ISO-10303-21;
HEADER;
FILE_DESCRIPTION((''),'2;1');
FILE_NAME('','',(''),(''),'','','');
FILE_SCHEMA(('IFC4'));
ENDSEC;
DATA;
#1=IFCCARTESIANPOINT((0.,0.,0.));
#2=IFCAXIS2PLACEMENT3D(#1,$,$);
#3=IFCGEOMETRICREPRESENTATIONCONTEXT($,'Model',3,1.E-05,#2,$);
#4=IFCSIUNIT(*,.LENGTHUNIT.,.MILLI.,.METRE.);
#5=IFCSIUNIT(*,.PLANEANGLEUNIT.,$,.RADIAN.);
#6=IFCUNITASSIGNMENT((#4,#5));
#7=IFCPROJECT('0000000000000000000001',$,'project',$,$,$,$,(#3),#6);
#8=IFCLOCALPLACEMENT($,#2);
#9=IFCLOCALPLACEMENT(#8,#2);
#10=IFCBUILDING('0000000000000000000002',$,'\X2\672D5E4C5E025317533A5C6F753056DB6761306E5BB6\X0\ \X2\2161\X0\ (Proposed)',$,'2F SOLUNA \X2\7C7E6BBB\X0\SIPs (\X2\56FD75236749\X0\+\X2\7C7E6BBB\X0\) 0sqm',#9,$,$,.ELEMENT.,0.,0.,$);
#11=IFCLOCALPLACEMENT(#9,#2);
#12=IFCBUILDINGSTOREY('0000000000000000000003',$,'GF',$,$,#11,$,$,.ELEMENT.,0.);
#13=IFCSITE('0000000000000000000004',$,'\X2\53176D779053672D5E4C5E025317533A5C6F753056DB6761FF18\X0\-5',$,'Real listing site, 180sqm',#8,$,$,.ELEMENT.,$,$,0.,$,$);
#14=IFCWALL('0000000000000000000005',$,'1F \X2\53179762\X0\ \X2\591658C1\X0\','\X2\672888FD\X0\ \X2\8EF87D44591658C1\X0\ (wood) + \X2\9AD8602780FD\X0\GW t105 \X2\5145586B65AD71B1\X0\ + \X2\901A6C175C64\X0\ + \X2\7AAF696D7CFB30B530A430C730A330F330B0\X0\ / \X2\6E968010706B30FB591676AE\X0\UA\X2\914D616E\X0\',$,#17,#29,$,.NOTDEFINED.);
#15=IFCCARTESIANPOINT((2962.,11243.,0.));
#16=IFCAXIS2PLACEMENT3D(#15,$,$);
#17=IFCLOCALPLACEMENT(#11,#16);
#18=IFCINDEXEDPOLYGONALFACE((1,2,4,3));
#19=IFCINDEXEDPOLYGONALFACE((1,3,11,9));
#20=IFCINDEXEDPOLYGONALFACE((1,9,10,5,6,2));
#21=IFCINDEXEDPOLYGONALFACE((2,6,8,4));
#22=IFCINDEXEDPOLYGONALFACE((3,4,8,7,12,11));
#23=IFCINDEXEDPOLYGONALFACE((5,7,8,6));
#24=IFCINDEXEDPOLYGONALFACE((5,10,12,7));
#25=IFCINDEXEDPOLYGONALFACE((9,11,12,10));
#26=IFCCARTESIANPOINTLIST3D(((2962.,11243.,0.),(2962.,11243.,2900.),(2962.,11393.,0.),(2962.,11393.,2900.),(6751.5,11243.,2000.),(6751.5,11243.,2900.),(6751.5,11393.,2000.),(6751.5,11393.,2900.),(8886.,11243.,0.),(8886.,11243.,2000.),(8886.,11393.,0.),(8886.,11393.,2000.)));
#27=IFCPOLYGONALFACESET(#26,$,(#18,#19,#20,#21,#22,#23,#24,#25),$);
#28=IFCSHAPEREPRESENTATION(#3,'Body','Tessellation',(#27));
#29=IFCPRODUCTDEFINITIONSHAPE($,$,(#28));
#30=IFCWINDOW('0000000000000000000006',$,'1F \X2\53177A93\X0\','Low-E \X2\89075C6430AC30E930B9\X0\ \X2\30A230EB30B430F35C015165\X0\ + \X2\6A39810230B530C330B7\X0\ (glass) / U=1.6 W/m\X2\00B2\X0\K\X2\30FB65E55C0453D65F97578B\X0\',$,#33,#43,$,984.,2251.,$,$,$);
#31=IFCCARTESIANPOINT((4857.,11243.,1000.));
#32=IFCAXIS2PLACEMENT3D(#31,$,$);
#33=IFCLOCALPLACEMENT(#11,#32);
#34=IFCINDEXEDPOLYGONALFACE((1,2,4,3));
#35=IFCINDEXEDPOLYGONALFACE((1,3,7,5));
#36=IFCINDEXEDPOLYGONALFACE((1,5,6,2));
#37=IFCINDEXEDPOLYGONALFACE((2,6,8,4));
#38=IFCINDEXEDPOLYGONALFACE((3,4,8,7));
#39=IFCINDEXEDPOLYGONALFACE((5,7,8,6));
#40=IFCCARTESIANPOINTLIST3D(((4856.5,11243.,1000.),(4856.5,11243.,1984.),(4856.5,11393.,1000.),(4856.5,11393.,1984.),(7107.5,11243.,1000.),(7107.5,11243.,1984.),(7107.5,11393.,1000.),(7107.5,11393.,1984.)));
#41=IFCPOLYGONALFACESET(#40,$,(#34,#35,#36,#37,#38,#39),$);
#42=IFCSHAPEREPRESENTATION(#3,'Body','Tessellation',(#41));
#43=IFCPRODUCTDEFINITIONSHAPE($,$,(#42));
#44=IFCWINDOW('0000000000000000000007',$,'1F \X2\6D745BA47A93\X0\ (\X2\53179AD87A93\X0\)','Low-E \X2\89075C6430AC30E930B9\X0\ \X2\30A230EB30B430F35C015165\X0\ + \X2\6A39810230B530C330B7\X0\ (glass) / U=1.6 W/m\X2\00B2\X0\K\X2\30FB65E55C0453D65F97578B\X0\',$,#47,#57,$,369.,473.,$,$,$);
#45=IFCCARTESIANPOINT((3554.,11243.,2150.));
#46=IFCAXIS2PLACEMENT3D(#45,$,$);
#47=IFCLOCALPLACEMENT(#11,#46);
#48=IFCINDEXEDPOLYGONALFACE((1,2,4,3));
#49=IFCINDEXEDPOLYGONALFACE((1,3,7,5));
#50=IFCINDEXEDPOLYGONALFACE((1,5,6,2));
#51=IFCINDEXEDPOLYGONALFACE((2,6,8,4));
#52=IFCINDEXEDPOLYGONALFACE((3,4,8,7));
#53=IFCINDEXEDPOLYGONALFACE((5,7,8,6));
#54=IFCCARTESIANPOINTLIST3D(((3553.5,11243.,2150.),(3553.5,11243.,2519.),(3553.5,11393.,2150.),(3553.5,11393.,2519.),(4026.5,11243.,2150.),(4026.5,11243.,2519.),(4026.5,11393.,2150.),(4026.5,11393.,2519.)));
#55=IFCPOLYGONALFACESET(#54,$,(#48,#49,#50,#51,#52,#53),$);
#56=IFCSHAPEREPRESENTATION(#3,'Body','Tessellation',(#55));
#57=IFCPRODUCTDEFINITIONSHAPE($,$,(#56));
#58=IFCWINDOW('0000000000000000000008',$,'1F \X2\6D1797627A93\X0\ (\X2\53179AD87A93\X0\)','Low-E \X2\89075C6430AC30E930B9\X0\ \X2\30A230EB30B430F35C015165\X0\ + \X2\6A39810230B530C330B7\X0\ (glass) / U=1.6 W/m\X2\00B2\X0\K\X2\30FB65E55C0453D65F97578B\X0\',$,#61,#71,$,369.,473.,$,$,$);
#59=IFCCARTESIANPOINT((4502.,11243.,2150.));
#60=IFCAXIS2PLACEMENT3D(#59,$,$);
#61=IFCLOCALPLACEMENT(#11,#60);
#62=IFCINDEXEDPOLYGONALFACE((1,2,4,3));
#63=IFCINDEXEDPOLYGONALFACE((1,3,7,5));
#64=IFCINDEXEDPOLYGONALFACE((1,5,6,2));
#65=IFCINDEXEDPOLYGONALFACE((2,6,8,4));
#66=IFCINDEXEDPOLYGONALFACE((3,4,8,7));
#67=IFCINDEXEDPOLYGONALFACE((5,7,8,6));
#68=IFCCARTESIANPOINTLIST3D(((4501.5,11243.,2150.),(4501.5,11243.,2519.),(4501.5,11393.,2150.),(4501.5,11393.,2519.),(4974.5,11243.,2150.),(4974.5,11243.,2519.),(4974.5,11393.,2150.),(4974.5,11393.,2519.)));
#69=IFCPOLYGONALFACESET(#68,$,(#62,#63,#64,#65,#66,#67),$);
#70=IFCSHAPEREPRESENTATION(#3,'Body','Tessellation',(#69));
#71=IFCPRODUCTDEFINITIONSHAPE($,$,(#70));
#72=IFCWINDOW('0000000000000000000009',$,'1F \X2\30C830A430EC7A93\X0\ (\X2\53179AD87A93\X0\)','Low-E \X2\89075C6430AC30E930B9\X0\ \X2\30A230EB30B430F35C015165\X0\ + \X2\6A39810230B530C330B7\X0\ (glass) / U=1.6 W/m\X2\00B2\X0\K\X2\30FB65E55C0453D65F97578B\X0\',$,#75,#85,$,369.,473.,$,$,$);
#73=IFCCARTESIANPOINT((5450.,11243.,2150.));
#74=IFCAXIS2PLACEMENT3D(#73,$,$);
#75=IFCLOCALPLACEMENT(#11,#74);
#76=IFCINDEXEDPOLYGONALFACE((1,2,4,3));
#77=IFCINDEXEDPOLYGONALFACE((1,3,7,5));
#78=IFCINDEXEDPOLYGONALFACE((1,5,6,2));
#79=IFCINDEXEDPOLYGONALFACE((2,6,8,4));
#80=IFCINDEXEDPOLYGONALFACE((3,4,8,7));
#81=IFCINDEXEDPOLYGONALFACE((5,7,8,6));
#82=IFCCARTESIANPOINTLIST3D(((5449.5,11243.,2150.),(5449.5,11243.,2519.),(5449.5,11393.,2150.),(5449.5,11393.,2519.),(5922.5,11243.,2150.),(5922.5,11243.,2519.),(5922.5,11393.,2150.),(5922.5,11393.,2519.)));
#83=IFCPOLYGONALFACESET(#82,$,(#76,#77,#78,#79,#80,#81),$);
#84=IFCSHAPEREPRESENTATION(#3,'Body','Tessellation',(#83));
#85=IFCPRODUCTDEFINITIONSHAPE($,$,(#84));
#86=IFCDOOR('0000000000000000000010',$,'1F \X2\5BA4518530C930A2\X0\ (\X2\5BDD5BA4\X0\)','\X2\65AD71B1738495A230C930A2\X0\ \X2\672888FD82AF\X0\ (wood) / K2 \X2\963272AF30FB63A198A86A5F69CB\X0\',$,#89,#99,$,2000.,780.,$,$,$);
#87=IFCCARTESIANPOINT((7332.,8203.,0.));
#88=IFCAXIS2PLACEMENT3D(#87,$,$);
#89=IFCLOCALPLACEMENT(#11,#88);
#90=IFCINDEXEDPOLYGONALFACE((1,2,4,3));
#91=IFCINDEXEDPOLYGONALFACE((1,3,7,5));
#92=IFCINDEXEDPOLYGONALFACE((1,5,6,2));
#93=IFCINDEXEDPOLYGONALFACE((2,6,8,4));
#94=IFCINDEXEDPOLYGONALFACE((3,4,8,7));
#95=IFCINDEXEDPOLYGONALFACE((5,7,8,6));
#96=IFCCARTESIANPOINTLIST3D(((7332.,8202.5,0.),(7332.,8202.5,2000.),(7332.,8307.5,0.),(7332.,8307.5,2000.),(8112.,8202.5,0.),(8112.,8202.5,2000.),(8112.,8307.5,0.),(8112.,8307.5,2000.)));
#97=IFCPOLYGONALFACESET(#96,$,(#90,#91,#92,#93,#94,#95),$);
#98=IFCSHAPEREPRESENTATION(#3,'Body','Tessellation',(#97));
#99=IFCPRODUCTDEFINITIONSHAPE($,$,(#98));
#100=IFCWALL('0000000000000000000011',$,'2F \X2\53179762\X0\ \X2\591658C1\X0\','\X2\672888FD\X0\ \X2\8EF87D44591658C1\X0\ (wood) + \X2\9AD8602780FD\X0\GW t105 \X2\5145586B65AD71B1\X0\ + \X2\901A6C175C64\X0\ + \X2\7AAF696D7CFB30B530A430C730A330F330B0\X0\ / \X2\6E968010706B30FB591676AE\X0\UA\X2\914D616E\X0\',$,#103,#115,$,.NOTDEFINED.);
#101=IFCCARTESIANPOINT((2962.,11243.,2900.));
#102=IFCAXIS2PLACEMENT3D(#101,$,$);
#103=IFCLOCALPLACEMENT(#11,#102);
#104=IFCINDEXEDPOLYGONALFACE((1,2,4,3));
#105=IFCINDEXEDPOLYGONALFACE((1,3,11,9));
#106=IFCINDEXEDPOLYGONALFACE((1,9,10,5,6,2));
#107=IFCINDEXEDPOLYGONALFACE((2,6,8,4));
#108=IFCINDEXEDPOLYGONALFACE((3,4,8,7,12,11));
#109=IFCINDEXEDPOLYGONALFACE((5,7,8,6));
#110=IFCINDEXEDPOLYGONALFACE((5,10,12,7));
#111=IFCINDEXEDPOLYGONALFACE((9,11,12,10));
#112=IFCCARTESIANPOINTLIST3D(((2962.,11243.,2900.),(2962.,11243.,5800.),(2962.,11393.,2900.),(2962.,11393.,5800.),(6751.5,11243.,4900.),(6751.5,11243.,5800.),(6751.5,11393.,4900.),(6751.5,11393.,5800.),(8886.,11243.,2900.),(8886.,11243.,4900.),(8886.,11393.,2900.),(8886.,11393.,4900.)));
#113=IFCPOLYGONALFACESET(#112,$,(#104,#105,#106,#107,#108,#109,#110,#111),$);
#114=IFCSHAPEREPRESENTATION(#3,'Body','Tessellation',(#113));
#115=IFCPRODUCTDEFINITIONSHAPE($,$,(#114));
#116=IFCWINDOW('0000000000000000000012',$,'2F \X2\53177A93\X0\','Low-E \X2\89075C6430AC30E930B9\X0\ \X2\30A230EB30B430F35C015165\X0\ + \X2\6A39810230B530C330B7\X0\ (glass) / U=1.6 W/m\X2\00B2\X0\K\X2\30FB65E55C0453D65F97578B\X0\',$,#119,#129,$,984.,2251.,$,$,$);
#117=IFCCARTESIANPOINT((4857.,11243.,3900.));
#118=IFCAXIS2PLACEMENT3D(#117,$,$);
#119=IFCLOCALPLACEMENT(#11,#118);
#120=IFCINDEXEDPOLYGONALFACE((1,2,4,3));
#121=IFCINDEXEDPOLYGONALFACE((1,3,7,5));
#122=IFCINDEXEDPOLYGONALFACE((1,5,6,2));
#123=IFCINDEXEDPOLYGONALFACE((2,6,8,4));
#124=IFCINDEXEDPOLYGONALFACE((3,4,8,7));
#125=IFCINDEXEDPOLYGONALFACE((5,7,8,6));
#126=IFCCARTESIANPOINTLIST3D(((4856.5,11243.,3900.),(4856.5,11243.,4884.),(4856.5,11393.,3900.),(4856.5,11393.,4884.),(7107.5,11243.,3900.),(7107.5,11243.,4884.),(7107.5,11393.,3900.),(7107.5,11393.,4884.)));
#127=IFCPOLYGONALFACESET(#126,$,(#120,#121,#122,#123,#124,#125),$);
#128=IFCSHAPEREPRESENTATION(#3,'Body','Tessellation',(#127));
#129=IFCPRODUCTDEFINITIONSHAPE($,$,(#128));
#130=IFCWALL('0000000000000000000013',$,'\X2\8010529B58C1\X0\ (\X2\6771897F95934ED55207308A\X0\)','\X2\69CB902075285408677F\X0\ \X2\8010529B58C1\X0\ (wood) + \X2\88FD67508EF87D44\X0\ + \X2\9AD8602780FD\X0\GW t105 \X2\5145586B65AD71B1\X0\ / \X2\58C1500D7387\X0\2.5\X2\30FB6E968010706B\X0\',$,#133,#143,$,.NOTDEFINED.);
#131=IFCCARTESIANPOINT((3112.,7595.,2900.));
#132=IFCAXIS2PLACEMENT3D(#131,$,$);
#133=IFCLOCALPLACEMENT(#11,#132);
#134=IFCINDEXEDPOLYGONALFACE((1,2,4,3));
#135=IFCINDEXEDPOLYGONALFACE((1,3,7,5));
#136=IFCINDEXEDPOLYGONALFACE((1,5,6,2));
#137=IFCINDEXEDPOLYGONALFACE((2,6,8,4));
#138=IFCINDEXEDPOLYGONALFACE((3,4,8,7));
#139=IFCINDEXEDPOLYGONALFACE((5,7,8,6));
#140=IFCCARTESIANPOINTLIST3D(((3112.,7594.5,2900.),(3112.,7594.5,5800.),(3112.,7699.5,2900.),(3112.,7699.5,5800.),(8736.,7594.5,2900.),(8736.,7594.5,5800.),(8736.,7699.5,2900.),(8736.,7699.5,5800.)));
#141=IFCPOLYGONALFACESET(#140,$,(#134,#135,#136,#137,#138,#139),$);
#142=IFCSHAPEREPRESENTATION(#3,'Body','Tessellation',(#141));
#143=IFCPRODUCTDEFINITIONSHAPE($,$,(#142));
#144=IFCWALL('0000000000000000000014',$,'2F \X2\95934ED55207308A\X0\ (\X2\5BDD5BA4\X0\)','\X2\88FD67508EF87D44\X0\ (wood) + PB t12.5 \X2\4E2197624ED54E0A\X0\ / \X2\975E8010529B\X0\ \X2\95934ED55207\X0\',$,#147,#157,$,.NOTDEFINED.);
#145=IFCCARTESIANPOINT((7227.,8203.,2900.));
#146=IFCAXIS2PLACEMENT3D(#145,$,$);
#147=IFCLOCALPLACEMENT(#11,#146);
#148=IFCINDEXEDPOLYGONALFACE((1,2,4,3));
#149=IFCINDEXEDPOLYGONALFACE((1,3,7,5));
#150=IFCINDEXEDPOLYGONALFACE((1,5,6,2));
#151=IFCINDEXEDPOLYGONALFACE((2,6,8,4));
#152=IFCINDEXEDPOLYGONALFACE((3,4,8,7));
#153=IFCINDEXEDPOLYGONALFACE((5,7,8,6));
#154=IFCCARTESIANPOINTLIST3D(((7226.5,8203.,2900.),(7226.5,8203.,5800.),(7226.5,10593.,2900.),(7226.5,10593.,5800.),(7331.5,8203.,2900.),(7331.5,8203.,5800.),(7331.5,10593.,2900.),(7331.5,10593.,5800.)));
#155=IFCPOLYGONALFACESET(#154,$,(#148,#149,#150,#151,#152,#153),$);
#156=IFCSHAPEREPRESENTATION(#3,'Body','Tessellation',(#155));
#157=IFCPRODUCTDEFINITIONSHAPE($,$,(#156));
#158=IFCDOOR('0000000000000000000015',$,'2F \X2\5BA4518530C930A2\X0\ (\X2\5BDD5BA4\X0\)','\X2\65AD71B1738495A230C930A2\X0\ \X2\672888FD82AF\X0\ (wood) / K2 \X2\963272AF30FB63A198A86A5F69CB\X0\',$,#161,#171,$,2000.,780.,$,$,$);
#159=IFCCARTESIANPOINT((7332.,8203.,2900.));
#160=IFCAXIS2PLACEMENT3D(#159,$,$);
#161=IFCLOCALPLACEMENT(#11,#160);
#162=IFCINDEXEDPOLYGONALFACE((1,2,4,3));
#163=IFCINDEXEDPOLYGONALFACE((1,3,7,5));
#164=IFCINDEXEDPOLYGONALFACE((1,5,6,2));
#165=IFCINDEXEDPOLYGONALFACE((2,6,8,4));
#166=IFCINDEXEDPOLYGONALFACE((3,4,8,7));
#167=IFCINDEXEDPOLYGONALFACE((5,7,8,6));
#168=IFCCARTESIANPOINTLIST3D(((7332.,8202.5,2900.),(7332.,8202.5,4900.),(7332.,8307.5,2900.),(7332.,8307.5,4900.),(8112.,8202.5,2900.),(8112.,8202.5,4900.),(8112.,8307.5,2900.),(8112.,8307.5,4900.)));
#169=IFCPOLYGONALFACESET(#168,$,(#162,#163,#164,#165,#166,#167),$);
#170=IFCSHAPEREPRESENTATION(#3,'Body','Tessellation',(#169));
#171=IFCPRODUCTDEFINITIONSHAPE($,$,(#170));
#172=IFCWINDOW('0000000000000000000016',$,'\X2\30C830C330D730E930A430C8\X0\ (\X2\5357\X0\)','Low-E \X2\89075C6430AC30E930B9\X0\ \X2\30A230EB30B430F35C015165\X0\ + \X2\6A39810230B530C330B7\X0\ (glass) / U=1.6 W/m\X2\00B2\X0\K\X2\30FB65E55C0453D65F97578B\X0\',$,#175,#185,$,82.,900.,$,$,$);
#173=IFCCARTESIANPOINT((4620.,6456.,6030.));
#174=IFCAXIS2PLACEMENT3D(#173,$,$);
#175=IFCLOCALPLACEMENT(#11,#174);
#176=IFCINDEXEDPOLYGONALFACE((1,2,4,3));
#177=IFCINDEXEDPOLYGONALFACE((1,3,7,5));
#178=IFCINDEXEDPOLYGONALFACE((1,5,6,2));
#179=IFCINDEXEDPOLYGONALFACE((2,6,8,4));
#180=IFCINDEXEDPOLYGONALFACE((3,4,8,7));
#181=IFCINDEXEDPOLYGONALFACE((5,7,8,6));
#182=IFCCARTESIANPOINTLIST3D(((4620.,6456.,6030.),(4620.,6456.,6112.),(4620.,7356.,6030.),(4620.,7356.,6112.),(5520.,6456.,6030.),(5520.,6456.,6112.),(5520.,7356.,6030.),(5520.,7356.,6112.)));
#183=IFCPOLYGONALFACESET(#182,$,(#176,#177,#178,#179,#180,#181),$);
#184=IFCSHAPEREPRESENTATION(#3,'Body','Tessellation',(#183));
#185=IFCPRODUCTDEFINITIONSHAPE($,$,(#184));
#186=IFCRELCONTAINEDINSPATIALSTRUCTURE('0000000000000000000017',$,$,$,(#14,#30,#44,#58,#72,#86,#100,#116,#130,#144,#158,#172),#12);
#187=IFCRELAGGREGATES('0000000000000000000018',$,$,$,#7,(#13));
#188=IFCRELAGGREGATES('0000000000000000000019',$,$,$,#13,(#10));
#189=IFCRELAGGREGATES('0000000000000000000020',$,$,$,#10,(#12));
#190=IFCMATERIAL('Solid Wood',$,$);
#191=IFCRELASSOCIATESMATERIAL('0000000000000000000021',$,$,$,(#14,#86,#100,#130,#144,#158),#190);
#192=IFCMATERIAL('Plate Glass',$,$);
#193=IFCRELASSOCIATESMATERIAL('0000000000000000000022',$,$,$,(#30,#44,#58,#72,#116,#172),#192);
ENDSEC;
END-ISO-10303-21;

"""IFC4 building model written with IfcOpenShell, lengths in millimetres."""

from ifc_helpers import new_model, si_unit, frame, frame_2d, origin, place, context, project, spatial, rectangle, extrude, material, element, fill, save


model = new_model("IFC4")

# Units and contexts
model_context = context("Model", 3, precision=1e-05, world=origin())
ifc_project = project(units=[si_unit("LENGTHUNIT", "METRE", prefix="MILLI"), si_unit("PLANEANGLEUNIT", "RADIAN")], contexts=[model_context])

# Site, building, storey
site_placement = place(None, origin())
site = spatial("IfcSite", under=ifc_project, at=site_placement, Name="北海道札幌市北区屯田四条８-5", ObjectType="Real listing site, 180sqm", CompositionType="ELEMENT", RefElevation=0.0)
building_placement = place(site_placement, origin())
building = spatial("IfcBuilding", under=site, at=building_placement, Name="札幌市北区屯田四条の家 Ⅱ (Proposed)", ObjectType="2F SOLUNA 籾殻SIPs (国産杉+籾殻) 0sqm", CompositionType="ELEMENT", ElevationOfRefHeight=0.0, ElevationOfTerrain=0.0)
storey_placement = place(building_placement, origin())
storey = spatial("IfcBuildingStorey", under=building, at=storey_placement, Name="GF", CompositionType="ELEMENT", Elevation=0.0)

# Wall, openings, windows
ifc_material_1 = material(Name="Solid Wood")
wall_1_placement = place(storey_placement, frame((2962.0, 11243.0, 0.0)))
wall_1 = element("IfcWall", 1, at=wall_1_placement, inside=storey, material=ifc_material_1, Name="1F 北面 外壁", Description="木製 軸組外壁 (wood) + 高性能GW t105 充填断熱 + 通気層 + 窯業系サイディング / 準耐火・外皮UA配慮", PredefinedType="NOTDEFINED", context=model_context, shape_type="SweptSolid", body=[
    extrude(rectangle(XDim=5924.0, YDim=150.0, at=frame_2d((2962.0, 75.0))), frame((2962.0, 11243.0, 0.0)), (0.0, 0.0, 1.0), 2900.0),
])
opening_1_placement = place(storey_placement, frame((4857.0, 11243.0, 1000.0)))
opening_1 = element("IfcOpeningElement", 2, at=opening_1_placement, cuts=wall_1, PredefinedType="NOTDEFINED", context=model_context, shape_type="SweptSolid", body=[
    extrude(rectangle(XDim=2251.0, YDim=150.0, at=frame_2d((1125.0, 75.0))), frame((4857.0, 11243.0, 1000.0)), (0.0, 0.0, 1.0), 984.0),
])
opening_2_placement = place(storey_placement, frame((3554.0, 11243.0, 2150.0)))
opening_2 = element("IfcOpeningElement", 3, at=opening_2_placement, cuts=wall_1, PredefinedType="NOTDEFINED", context=model_context, shape_type="SweptSolid", body=[
    extrude(rectangle(XDim=473.0, YDim=150.0, at=frame_2d((236.0, 75.0))), frame((3554.0, 11243.0, 2150.0)), (0.0, 0.0, 1.0), 369.0),
])
opening_3_placement = place(storey_placement, frame((4502.0, 11243.0, 2150.0)))
opening_3 = element("IfcOpeningElement", 4, at=opening_3_placement, cuts=wall_1, PredefinedType="NOTDEFINED", context=model_context, shape_type="SweptSolid", body=[
    extrude(rectangle(XDim=473.0, YDim=150.0, at=frame_2d((236.0, 75.0))), frame((4502.0, 11243.0, 2150.0)), (0.0, 0.0, 1.0), 369.0),
])
opening_4_placement = place(storey_placement, frame((5450.0, 11243.0, 2150.0)))
opening_4 = element("IfcOpeningElement", 5, at=opening_4_placement, cuts=wall_1, PredefinedType="NOTDEFINED", context=model_context, shape_type="SweptSolid", body=[
    extrude(rectangle(XDim=473.0, YDim=150.0, at=frame_2d((236.0, 75.0))), frame((5450.0, 11243.0, 2150.0)), (0.0, 0.0, 1.0), 369.0),
])
ifc_material_2 = material(Name="Plate Glass")
window_1_placement = place(storey_placement, frame((4857.0, 11243.0, 1000.0)))
window_1 = element("IfcWindow", 6, at=window_1_placement, inside=storey, material=ifc_material_2, Name="1F 北窓", Description="Low-E 複層ガラス アルゴン封入 + 樹脂サッシ (glass) / U=1.6 W/m²K・日射取得型", OverallHeight=984.0, OverallWidth=2251.0, context=model_context, shape_type="SweptSolid", body=[
    extrude(rectangle(XDim=2251.0, YDim=150.0, at=frame_2d((1125.0, 75.0))), frame((4857.0, 11243.0, 1000.0)), (0.0, 0.0, 1.0), 984.0),
])
fill(opening_1, window_1)
window_2_placement = place(storey_placement, frame((3554.0, 11243.0, 2150.0)))
window_2 = element("IfcWindow", 7, at=window_2_placement, inside=storey, material=ifc_material_2, Name="1F 浴室窓 (北高窓)", Description="Low-E 複層ガラス アルゴン封入 + 樹脂サッシ (glass) / U=1.6 W/m²K・日射取得型", OverallHeight=369.0, OverallWidth=473.0, context=model_context, shape_type="SweptSolid", body=[
    extrude(rectangle(XDim=473.0, YDim=150.0, at=frame_2d((236.0, 75.0))), frame((3554.0, 11243.0, 2150.0)), (0.0, 0.0, 1.0), 369.0),
])
fill(opening_2, window_2)
window_3_placement = place(storey_placement, frame((4502.0, 11243.0, 2150.0)))
window_3 = element("IfcWindow", 8, at=window_3_placement, inside=storey, material=ifc_material_2, Name="1F 洗面窓 (北高窓)", Description="Low-E 複層ガラス アルゴン封入 + 樹脂サッシ (glass) / U=1.6 W/m²K・日射取得型", OverallHeight=369.0, OverallWidth=473.0, context=model_context, shape_type="SweptSolid", body=[
    extrude(rectangle(XDim=473.0, YDim=150.0, at=frame_2d((236.0, 75.0))), frame((4502.0, 11243.0, 2150.0)), (0.0, 0.0, 1.0), 369.0),
])
fill(opening_3, window_3)
window_4_placement = place(storey_placement, frame((5450.0, 11243.0, 2150.0)))
window_4 = element("IfcWindow", 9, at=window_4_placement, inside=storey, material=ifc_material_2, Name="1F トイレ窓 (北高窓)", Description="Low-E 複層ガラス アルゴン封入 + 樹脂サッシ (glass) / U=1.6 W/m²K・日射取得型", OverallHeight=369.0, OverallWidth=473.0, context=model_context, shape_type="SweptSolid", body=[
    extrude(rectangle(XDim=473.0, YDim=150.0, at=frame_2d((236.0, 75.0))), frame((5450.0, 11243.0, 2150.0)), (0.0, 0.0, 1.0), 369.0),
])
fill(opening_4, window_4)

# Door
door_1_placement = place(storey_placement, frame((7332.0, 8203.0, 0.0)))
element("IfcDoor", 10, at=door_1_placement, inside=storey, material=ifc_material_1, Name="1F 室内ドア (寝室)", Description="断熱玄関ドア 木製芯 (wood) / K2 防犯・採風機構", OverallHeight=2000.0, OverallWidth=780.0, context=model_context, shape_type="SweptSolid", body=[
    extrude(rectangle(XDim=780.0, YDim=105.0, at=frame_2d((390.0, 52.0))), frame((7332.0, 8203.0, 0.0)), (0.0, 0.0, 1.0), 2000.0),
])

# Wall, opening, window
wall_2_placement = place(storey_placement, frame((2962.0, 11243.0, 2900.0)))
wall_2 = element("IfcWall", 11, at=wall_2_placement, inside=storey, material=ifc_material_1, Name="2F 北面 外壁", Description="木製 軸組外壁 (wood) + 高性能GW t105 充填断熱 + 通気層 + 窯業系サイディング / 準耐火・外皮UA配慮", PredefinedType="NOTDEFINED", context=model_context, shape_type="SweptSolid", body=[
    extrude(rectangle(XDim=5924.0, YDim=150.0, at=frame_2d((2962.0, 75.0))), frame((2962.0, 11243.0, 2900.0)), (0.0, 0.0, 1.0), 2900.0),
])
opening_5_placement = place(storey_placement, frame((4857.0, 11243.0, 3900.0)))
opening_5 = element("IfcOpeningElement", 12, at=opening_5_placement, cuts=wall_2, PredefinedType="NOTDEFINED", context=model_context, shape_type="SweptSolid", body=[
    extrude(rectangle(XDim=2251.0, YDim=150.0, at=frame_2d((1125.0, 75.0))), frame((4857.0, 11243.0, 3900.0)), (0.0, 0.0, 1.0), 984.0),
])
window_5_placement = place(storey_placement, frame((4857.0, 11243.0, 3900.0)))
window_5 = element("IfcWindow", 13, at=window_5_placement, inside=storey, material=ifc_material_2, Name="2F 北窓", Description="Low-E 複層ガラス アルゴン封入 + 樹脂サッシ (glass) / U=1.6 W/m²K・日射取得型", OverallHeight=984.0, OverallWidth=2251.0, context=model_context, shape_type="SweptSolid", body=[
    extrude(rectangle(XDim=2251.0, YDim=150.0, at=frame_2d((1125.0, 75.0))), frame((4857.0, 11243.0, 3900.0)), (0.0, 0.0, 1.0), 984.0),
])
fill(opening_5, window_5)

# Walls
wall_3_placement = place(storey_placement, frame((3112.0, 7595.0, 2900.0)))
element("IfcWall", 14, at=wall_3_placement, inside=storey, material=ifc_material_1, Name="耐力壁 (東西間仕切り)", Description="構造用合板 耐力壁 (wood) + 製材軸組 + 高性能GW t105 充填断熱 / 壁倍率2.5・準耐火", PredefinedType="NOTDEFINED", context=model_context, shape_type="SweptSolid", body=[
    extrude(rectangle(XDim=5624.0, YDim=105.0, at=frame_2d((2812.0, 52.0))), frame((3112.0, 7595.0, 2900.0)), (0.0, 0.0, 1.0), 2900.0),
])
wall_4_placement = place(storey_placement, frame((7227.0, 8203.0, 2900.0)))
element("IfcWall", 15, at=wall_4_placement, inside=storey, material=ifc_material_1, Name="2F 間仕切り (寝室)", Description="製材軸組 (wood) + PB t12.5 両面仕上 / 非耐力 間仕切", PredefinedType="NOTDEFINED", context=model_context, shape_type="SweptSolid", body=[
    extrude(rectangle(XDim=105.0, YDim=2390.0, at=frame_2d((52.0, 1195.0))), frame((7227.0, 8203.0, 2900.0)), (0.0, 0.0, 1.0), 2900.0),
])

# Door
door_2_placement = place(storey_placement, frame((7332.0, 8203.0, 2900.0)))
element("IfcDoor", 16, at=door_2_placement, inside=storey, material=ifc_material_1, Name="2F 室内ドア (寝室)", Description="断熱玄関ドア 木製芯 (wood) / K2 防犯・採風機構", OverallHeight=2000.0, OverallWidth=780.0, context=model_context, shape_type="SweptSolid", body=[
    extrude(rectangle(XDim=780.0, YDim=105.0, at=frame_2d((390.0, 52.0))), frame((7332.0, 8203.0, 2900.0)), (0.0, 0.0, 1.0), 2000.0),
])

# Window
window_6_placement = place(storey_placement, frame((4620.0, 6456.0, 6030.0)))
element("IfcWindow", 17, at=window_6_placement, inside=storey, material=ifc_material_2, Name="トップライト (南)", Description="Low-E 複層ガラス アルゴン封入 + 樹脂サッシ (glass) / U=1.6 W/m²K・日射取得型", OverallHeight=82.0, OverallWidth=900.0, context=model_context, shape_type="SweptSolid", body=[
    extrude(rectangle(XDim=900.0, YDim=900.0, at=frame_2d((450.0, 450.0))), frame((4620.0, 6456.0, 6030.0)), (0.0, 0.0, 1.0), 82.0),
])

save(model, "model.ifc")
